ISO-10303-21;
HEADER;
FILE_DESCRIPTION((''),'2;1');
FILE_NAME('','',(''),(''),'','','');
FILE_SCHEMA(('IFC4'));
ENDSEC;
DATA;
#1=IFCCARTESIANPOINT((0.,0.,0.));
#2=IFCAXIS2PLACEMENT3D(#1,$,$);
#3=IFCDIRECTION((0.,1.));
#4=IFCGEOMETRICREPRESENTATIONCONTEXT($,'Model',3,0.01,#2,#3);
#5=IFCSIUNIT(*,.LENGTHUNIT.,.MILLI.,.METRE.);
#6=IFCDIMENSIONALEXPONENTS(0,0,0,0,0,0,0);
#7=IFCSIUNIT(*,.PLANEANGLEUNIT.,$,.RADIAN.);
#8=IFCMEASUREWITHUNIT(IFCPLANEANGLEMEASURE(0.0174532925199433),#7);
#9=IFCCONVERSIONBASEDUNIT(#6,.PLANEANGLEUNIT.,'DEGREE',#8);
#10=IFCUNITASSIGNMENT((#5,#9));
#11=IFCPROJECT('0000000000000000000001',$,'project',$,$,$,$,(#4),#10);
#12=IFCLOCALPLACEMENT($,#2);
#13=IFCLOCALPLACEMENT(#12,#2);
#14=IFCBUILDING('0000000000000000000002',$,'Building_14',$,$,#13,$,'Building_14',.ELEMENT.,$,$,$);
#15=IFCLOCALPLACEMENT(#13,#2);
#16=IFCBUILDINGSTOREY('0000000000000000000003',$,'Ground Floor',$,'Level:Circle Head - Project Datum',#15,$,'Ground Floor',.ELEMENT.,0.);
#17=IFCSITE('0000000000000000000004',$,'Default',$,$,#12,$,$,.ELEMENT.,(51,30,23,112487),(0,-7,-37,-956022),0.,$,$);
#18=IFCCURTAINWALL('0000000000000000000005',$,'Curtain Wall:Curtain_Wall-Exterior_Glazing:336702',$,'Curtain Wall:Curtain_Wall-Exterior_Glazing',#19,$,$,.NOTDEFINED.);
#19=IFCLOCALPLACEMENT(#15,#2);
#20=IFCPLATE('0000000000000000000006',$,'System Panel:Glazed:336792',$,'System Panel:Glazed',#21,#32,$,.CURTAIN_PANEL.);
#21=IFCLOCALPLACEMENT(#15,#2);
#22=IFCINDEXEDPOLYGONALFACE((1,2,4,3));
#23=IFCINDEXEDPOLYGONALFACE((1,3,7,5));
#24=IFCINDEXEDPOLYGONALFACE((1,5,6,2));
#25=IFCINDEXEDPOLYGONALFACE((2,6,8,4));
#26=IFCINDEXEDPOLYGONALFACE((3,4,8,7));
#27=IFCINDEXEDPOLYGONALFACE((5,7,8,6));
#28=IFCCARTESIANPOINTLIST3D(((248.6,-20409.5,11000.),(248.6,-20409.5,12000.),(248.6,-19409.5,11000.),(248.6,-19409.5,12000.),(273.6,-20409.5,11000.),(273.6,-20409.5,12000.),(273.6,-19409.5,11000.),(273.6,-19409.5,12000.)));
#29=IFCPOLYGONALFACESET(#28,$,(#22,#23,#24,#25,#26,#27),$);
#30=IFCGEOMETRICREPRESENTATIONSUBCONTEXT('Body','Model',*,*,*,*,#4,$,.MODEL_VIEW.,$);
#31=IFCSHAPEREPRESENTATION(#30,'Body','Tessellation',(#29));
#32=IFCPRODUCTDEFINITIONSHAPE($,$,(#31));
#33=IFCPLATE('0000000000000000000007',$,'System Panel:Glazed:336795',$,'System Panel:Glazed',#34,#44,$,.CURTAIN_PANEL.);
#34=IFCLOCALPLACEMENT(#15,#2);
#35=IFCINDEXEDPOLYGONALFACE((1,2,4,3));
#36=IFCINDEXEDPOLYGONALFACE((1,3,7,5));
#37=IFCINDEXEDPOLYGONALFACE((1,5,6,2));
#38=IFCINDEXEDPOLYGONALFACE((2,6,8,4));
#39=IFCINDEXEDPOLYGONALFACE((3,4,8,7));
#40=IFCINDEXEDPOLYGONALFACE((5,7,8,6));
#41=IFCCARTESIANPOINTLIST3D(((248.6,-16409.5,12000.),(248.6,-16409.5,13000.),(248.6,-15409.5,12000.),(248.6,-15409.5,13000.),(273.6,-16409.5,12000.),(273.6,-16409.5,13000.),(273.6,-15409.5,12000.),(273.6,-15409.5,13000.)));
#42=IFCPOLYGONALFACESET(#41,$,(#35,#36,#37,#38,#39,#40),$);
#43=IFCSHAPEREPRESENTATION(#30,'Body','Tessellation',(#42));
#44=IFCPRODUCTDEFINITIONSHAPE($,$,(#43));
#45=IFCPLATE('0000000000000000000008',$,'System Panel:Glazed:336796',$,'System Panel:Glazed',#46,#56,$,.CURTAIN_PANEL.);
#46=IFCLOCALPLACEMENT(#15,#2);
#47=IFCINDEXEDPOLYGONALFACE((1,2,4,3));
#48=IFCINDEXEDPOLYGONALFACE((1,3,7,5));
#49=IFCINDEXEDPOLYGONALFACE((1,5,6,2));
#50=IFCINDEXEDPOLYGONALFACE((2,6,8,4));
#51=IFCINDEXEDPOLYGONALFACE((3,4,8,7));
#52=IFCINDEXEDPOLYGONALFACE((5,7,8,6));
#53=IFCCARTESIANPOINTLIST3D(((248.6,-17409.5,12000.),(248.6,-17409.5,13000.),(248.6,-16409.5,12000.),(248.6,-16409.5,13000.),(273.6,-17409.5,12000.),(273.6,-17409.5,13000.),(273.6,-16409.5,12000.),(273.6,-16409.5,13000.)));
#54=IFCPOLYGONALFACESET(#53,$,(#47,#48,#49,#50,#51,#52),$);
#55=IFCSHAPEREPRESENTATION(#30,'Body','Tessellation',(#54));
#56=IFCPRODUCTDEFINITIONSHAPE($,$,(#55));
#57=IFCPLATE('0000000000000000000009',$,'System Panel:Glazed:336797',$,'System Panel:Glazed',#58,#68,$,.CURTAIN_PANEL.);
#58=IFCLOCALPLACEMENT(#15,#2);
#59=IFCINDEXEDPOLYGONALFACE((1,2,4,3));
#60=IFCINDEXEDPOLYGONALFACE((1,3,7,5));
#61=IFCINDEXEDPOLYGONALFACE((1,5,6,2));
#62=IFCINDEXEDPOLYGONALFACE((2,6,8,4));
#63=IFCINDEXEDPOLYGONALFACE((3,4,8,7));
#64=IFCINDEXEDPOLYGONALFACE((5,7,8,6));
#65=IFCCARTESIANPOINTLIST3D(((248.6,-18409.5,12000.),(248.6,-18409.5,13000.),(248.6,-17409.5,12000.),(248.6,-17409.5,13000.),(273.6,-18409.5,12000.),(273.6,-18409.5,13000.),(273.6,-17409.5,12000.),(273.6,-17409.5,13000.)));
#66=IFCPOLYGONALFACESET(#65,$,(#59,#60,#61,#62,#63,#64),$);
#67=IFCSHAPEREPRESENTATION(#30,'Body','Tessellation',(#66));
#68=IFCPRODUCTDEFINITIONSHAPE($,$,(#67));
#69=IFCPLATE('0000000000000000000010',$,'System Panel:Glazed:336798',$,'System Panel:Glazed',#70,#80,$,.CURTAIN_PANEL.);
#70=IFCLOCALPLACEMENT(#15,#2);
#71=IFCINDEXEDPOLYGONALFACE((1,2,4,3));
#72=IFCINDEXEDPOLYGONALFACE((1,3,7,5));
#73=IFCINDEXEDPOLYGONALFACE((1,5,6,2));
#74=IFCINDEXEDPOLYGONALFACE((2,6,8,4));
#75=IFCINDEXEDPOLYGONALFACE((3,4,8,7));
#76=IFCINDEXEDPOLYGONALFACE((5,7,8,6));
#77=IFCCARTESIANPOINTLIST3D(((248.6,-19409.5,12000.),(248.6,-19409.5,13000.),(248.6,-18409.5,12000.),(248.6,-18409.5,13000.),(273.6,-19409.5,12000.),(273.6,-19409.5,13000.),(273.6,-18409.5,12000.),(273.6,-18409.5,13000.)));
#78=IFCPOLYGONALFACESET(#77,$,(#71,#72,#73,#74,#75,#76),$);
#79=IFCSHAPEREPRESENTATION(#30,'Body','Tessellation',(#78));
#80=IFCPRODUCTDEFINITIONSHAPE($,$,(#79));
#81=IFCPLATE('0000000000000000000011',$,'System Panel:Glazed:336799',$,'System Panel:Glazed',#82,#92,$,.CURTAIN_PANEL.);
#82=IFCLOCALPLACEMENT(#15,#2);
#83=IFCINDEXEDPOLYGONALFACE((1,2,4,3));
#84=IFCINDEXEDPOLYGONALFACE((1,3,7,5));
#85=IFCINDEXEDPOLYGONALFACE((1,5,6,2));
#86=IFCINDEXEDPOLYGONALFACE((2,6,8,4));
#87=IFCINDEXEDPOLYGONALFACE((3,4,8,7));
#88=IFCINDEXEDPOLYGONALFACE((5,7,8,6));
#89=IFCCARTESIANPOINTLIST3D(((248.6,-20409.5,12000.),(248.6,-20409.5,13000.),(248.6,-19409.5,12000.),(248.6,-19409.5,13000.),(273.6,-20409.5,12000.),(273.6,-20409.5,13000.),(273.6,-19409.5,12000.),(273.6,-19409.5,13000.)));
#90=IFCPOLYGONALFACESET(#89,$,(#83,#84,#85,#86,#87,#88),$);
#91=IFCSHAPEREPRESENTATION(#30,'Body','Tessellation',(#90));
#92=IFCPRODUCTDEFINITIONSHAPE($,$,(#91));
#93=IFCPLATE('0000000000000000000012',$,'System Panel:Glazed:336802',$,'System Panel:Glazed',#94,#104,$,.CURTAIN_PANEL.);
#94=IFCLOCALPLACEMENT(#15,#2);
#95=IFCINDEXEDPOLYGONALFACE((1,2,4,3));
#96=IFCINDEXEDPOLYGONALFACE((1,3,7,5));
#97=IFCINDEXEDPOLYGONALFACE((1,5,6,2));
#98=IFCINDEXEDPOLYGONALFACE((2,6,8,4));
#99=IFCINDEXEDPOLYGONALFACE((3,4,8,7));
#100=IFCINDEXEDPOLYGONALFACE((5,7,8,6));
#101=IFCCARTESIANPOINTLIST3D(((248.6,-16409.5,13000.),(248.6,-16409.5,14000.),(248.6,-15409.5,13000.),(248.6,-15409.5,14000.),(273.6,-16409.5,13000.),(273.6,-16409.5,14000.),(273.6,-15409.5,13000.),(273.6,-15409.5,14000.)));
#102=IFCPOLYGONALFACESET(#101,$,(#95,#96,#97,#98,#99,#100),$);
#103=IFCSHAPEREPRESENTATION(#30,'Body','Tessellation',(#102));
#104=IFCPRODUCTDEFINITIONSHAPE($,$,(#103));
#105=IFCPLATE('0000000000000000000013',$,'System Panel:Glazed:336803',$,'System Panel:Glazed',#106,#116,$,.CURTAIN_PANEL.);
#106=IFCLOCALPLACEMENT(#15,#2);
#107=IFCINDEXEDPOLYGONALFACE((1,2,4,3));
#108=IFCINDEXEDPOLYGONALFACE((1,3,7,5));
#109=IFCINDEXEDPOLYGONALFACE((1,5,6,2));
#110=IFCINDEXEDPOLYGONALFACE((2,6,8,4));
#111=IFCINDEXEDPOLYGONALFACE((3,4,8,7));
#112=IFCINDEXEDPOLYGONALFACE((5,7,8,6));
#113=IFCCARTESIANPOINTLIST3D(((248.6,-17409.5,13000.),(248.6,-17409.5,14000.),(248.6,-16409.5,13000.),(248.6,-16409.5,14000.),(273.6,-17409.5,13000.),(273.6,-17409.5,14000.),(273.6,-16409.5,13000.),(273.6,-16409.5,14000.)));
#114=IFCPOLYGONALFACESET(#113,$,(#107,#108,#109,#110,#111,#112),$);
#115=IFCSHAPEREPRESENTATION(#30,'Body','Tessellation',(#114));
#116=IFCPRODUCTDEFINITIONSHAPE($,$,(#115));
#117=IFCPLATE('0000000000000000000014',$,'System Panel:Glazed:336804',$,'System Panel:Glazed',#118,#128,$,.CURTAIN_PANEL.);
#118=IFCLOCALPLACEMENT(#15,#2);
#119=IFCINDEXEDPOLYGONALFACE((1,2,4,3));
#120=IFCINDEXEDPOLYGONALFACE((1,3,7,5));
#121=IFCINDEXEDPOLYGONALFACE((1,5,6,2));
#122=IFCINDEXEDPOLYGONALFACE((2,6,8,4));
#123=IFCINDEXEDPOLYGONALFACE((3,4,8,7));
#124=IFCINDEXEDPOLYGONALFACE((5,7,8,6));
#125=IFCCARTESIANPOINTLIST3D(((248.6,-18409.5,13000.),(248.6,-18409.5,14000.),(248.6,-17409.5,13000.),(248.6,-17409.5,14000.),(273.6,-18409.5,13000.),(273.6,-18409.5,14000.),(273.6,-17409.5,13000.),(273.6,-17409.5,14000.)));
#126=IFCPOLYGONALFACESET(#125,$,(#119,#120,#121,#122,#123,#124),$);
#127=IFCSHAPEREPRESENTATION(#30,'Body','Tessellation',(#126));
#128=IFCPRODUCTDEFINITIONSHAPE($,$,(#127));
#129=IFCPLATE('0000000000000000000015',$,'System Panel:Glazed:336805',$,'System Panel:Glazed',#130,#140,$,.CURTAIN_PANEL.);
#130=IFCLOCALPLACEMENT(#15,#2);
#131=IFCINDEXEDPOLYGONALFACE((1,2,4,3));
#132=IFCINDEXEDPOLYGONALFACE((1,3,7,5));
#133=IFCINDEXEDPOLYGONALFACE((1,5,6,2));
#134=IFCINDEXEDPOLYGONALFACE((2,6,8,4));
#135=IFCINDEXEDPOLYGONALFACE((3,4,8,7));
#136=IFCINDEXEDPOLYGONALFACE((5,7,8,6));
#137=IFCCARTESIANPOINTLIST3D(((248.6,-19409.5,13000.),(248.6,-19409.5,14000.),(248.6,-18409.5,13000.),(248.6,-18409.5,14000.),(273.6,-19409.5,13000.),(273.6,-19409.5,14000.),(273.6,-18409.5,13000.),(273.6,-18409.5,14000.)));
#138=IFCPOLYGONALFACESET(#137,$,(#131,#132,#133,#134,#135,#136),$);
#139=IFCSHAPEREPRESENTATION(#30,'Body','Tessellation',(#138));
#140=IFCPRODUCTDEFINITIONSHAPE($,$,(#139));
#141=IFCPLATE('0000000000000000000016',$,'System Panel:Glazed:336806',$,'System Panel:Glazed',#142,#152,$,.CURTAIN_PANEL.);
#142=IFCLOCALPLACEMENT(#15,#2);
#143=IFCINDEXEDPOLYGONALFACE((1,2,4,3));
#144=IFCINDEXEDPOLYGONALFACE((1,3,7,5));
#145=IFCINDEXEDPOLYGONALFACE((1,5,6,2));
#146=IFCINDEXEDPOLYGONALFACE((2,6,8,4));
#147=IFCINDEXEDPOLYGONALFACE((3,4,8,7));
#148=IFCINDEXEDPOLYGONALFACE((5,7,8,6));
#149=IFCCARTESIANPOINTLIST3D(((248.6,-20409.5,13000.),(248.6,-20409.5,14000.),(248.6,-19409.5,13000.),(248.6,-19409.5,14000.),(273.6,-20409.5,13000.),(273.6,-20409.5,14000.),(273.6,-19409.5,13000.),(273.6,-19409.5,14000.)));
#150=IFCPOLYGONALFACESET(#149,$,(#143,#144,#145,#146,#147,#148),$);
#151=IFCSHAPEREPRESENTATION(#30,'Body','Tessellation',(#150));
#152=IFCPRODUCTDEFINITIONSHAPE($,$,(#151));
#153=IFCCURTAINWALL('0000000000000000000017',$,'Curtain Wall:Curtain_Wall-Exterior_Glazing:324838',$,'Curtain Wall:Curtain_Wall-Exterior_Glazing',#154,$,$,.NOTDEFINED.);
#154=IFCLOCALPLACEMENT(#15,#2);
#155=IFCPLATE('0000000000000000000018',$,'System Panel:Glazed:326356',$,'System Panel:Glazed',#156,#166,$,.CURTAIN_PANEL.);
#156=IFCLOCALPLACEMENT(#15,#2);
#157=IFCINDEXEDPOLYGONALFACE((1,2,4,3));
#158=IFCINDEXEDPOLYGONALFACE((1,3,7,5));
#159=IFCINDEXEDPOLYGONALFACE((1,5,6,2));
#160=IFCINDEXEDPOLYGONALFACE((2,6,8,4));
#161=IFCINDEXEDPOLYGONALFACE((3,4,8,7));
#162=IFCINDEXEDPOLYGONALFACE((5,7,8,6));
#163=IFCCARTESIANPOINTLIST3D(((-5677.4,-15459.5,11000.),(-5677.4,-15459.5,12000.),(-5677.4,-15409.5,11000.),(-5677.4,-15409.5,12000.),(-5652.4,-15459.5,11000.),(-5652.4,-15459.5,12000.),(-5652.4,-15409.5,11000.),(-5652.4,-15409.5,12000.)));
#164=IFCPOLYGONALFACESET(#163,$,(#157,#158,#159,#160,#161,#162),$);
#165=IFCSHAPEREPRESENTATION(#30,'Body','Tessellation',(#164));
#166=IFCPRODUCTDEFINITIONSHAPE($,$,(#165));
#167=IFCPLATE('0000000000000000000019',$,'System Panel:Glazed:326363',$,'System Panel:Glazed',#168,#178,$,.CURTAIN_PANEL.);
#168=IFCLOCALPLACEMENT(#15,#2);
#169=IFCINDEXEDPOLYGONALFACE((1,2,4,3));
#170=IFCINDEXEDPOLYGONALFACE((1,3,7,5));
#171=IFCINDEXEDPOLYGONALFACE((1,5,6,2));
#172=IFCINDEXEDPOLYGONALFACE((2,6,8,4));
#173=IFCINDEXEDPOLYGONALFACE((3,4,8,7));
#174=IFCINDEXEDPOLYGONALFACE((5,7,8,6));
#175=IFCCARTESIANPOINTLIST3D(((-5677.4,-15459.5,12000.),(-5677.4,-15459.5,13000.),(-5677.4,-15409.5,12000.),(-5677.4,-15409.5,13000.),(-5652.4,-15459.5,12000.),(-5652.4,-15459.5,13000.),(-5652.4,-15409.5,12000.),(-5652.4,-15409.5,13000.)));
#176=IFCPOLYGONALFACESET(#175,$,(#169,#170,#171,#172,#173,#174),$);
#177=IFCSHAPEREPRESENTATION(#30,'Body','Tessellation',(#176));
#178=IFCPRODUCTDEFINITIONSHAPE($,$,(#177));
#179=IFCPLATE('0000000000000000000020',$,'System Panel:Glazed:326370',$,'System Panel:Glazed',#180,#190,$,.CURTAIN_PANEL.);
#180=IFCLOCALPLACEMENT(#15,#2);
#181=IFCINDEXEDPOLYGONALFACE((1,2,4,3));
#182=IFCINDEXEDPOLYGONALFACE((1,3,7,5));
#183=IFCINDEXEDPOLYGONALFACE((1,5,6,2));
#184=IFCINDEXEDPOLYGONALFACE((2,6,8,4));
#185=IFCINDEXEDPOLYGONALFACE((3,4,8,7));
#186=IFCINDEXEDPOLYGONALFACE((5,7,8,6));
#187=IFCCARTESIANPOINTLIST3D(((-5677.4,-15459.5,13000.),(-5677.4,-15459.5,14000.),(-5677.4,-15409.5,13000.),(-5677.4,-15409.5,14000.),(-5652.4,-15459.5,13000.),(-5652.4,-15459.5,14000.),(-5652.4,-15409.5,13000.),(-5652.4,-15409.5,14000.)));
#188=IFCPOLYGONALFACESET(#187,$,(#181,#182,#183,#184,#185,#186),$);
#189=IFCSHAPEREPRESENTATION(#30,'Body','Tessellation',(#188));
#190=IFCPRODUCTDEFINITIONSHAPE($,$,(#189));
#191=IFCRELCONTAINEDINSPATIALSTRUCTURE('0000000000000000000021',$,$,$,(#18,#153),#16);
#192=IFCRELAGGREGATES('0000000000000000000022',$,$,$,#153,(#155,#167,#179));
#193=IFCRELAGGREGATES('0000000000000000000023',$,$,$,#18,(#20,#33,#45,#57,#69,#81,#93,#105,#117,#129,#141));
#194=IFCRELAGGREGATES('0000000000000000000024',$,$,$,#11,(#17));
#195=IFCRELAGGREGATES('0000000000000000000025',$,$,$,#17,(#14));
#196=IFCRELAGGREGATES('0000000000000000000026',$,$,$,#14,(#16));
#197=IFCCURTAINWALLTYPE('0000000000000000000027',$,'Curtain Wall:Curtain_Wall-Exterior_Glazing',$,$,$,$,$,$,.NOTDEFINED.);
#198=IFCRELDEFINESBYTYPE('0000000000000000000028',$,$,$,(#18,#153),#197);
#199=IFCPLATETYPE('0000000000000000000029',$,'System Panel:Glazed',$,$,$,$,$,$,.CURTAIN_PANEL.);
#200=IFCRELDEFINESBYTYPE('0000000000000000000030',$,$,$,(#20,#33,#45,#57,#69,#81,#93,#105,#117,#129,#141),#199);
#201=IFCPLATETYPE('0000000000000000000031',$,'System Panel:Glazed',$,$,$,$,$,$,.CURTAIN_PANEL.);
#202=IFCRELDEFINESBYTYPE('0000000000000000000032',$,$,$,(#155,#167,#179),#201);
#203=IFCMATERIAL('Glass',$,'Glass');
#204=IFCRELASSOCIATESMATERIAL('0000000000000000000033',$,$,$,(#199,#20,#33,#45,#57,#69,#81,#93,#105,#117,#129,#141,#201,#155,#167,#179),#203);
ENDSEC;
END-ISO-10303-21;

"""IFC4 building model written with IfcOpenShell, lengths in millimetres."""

from ifc_helpers import new_model, entity, si_unit, converted_unit, direction, frame, origin, place, context, subcontext, project, spatial, indexed_curve, outline, extrude, source, transform, mapped, material, type_object, type_shapes, element, aggregate, save


model = new_model("IFC4")

# Units and contexts
model_context = context("Model", 3, precision=0.01, world=origin(), true_north=direction((0.0, 1.0)))
body_context = subcontext(model_context, "Body", "Model", "MODEL_VIEW")
ifc_project = project(units=[si_unit("LENGTHUNIT", "METRE", prefix="MILLI"), converted_unit("PLANEANGLEUNIT", "DEGREE", entity("IfcPlaneAngleMeasure", 0.0174532925199433), si_unit("PLANEANGLEUNIT", "RADIAN"), dimensions=[0, 0, 0, 0, 0, 0, 0])], contexts=[model_context])

# Site, building, storey
site_placement = place(None, origin())
site = spatial("IfcSite", under=ifc_project, at=site_placement, Name="Default", CompositionType="ELEMENT", RefLatitude=(51, 30, 23, 112487), RefLongitude=(0, -7, -37, -956022), RefElevation=0.0)
building_placement = place(site_placement, origin())
building = spatial("IfcBuilding", under=site, at=building_placement, Name="Building_14", LongName="Building_14", CompositionType="ELEMENT")
storey_placement = place(building_placement, origin())
storey = spatial("IfcBuildingStorey", under=building, at=storey_placement, Name="Ground Floor", ObjectType="Level:Circle Head - Project Datum", LongName="Ground Floor", CompositionType="ELEMENT", Elevation=0.0)

# Curtain walls, plates
curtain_wall_type = type_object("IfcCurtainWallType", Name="Curtain Wall:Curtain_Wall-Exterior_Glazing", PredefinedType="NOTDEFINED")
curtain_wall_1_placement = place(storey_placement, origin())
curtain_wall_1 = element("IfcCurtainWall", 1, at=curtain_wall_1_placement, inside=storey, type_object=curtain_wall_type, Name="Curtain Wall:Curtain_Wall-Exterior_Glazing:336702", ObjectType="Curtain Wall:Curtain_Wall-Exterior_Glazing", PredefinedType="NOTDEFINED")
ifc_material = material(Name="Glass", Category="Glass")
plate_type_1 = type_object("IfcPlateType", Name="System Panel:Glazed", PredefinedType="CURTAIN_PANEL", material=ifc_material)
shared_shape_1 = source(origin(), body_context, "Body", "SweptSolid", [
    extrude(outline(indexed_curve([(-12.5, -500.0), (12.5, -500.0), (12.5, 500.0), (-12.5, 500.0), (-12.5, -500.0)], self_intersect=False)), frame((0.0, -37.0, 0.0), z_axis=(0.0, 0.0, 1.0), x_axis=(0.0, 1.0, 0.0)), (0.0, 0.0, 1.0), 1000.0),
])
type_shapes(plate_type_1, [shared_shape_1])
plate_1_placement = place(curtain_wall_1_placement, frame((298.1, -19909.5, 11000.0), z_axis=(0.0, 0.0, 1.0), x_axis=(0.0, -1.0, 0.0)))
plate_1 = element("IfcPlate", 2, at=plate_1_placement, type_object=plate_type_1, material=ifc_material, Name="System Panel:Glazed:336792", ObjectType="System Panel:Glazed", PredefinedType="CURTAIN_PANEL", context=body_context, shape_type="MappedRepresentation", body=[
    mapped(shared_shape_1, transform((0.0, 0.0, 0.0), scale=1.0)),
])
plate_2_placement = place(curtain_wall_1_placement, frame((298.1, -15909.5, 12000.0), z_axis=(0.0, 0.0, 1.0), x_axis=(0.0, -1.0, 0.0)))
plate_2 = element("IfcPlate", 3, at=plate_2_placement, type_object=plate_type_1, material=ifc_material, Name="System Panel:Glazed:336795", ObjectType="System Panel:Glazed", PredefinedType="CURTAIN_PANEL", context=body_context, shape_type="MappedRepresentation", body=[
    mapped(shared_shape_1, transform((0.0, 0.0, 0.0), scale=1.0)),
])
plate_3_placement = place(curtain_wall_1_placement, frame((298.1, -16909.5, 12000.0), z_axis=(0.0, 0.0, 1.0), x_axis=(0.0, -1.0, 0.0)))
plate_3 = element("IfcPlate", 4, at=plate_3_placement, type_object=plate_type_1, material=ifc_material, Name="System Panel:Glazed:336796", ObjectType="System Panel:Glazed", PredefinedType="CURTAIN_PANEL", context=body_context, shape_type="MappedRepresentation", body=[
    mapped(shared_shape_1, transform((0.0, 0.0, 0.0), scale=1.0)),
])
plate_4_placement = place(curtain_wall_1_placement, frame((298.1, -17909.5, 12000.0), z_axis=(0.0, 0.0, 1.0), x_axis=(0.0, -1.0, 0.0)))
plate_4 = element("IfcPlate", 5, at=plate_4_placement, type_object=plate_type_1, material=ifc_material, Name="System Panel:Glazed:336797", ObjectType="System Panel:Glazed", PredefinedType="CURTAIN_PANEL", context=body_context, shape_type="MappedRepresentation", body=[
    mapped(shared_shape_1, transform((0.0, 0.0, 0.0), scale=1.0)),
])
plate_5_placement = place(curtain_wall_1_placement, frame((298.1, -18909.5, 12000.0), z_axis=(0.0, 0.0, 1.0), x_axis=(0.0, -1.0, 0.0)))
plate_5 = element("IfcPlate", 6, at=plate_5_placement, type_object=plate_type_1, material=ifc_material, Name="System Panel:Glazed:336798", ObjectType="System Panel:Glazed", PredefinedType="CURTAIN_PANEL", context=body_context, shape_type="MappedRepresentation", body=[
    mapped(shared_shape_1, transform((0.0, 0.0, 0.0), scale=1.0)),
])
plate_6_placement = place(curtain_wall_1_placement, frame((298.1, -19909.5, 12000.0), z_axis=(0.0, 0.0, 1.0), x_axis=(0.0, -1.0, 0.0)))
plate_6 = element("IfcPlate", 7, at=plate_6_placement, type_object=plate_type_1, material=ifc_material, Name="System Panel:Glazed:336799", ObjectType="System Panel:Glazed", PredefinedType="CURTAIN_PANEL", context=body_context, shape_type="MappedRepresentation", body=[
    mapped(shared_shape_1, transform((0.0, 0.0, 0.0), scale=1.0)),
])
plate_7_placement = place(curtain_wall_1_placement, frame((298.1, -15909.5, 13000.0), z_axis=(0.0, 0.0, 1.0), x_axis=(0.0, -1.0, 0.0)))
plate_7 = element("IfcPlate", 8, at=plate_7_placement, type_object=plate_type_1, material=ifc_material, Name="System Panel:Glazed:336802", ObjectType="System Panel:Glazed", PredefinedType="CURTAIN_PANEL", context=body_context, shape_type="MappedRepresentation", body=[
    mapped(shared_shape_1, transform((0.0, 0.0, 0.0), scale=1.0)),
])
plate_8_placement = place(curtain_wall_1_placement, frame((298.1, -16909.5, 13000.0), z_axis=(0.0, 0.0, 1.0), x_axis=(0.0, -1.0, 0.0)))
plate_8 = element("IfcPlate", 9, at=plate_8_placement, type_object=plate_type_1, material=ifc_material, Name="System Panel:Glazed:336803", ObjectType="System Panel:Glazed", PredefinedType="CURTAIN_PANEL", context=body_context, shape_type="MappedRepresentation", body=[
    mapped(shared_shape_1, transform((0.0, 0.0, 0.0), scale=1.0)),
])
plate_9_placement = place(curtain_wall_1_placement, frame((298.1, -17909.5, 13000.0), z_axis=(0.0, 0.0, 1.0), x_axis=(0.0, -1.0, 0.0)))
plate_9 = element("IfcPlate", 10, at=plate_9_placement, type_object=plate_type_1, material=ifc_material, Name="System Panel:Glazed:336804", ObjectType="System Panel:Glazed", PredefinedType="CURTAIN_PANEL", context=body_context, shape_type="MappedRepresentation", body=[
    mapped(shared_shape_1, transform((0.0, 0.0, 0.0), scale=1.0)),
])
plate_10_placement = place(curtain_wall_1_placement, frame((298.1, -18909.5, 13000.0), z_axis=(0.0, 0.0, 1.0), x_axis=(0.0, -1.0, 0.0)))
plate_10 = element("IfcPlate", 11, at=plate_10_placement, type_object=plate_type_1, material=ifc_material, Name="System Panel:Glazed:336805", ObjectType="System Panel:Glazed", PredefinedType="CURTAIN_PANEL", context=body_context, shape_type="MappedRepresentation", body=[
    mapped(shared_shape_1, transform((0.0, 0.0, 0.0), scale=1.0)),
])
plate_11_placement = place(curtain_wall_1_placement, frame((298.1, -19909.5, 13000.0), z_axis=(0.0, 0.0, 1.0), x_axis=(0.0, -1.0, 0.0)))
plate_11 = element("IfcPlate", 12, at=plate_11_placement, type_object=plate_type_1, material=ifc_material, Name="System Panel:Glazed:336806", ObjectType="System Panel:Glazed", PredefinedType="CURTAIN_PANEL", context=body_context, shape_type="MappedRepresentation", body=[
    mapped(shared_shape_1, transform((0.0, 0.0, 0.0), scale=1.0)),
])
curtain_wall_2_placement = place(storey_placement, origin())
curtain_wall_2 = element("IfcCurtainWall", 13, at=curtain_wall_2_placement, inside=storey, type_object=curtain_wall_type, Name="Curtain Wall:Curtain_Wall-Exterior_Glazing:324838", ObjectType="Curtain Wall:Curtain_Wall-Exterior_Glazing", PredefinedType="NOTDEFINED")
plate_type_2 = type_object("IfcPlateType", Name="System Panel:Glazed", PredefinedType="CURTAIN_PANEL", material=ifc_material)
shared_shape_2 = source(origin(), body_context, "Body", "SweptSolid", [
    extrude(outline(indexed_curve([(-12.5, -25.0), (12.5, -25.0), (12.5, 25.0), (-12.5, 25.0), (-12.5, -25.0)], self_intersect=False)), frame((0.0, -37.0, 0.0), z_axis=(0.0, 0.0, 1.0), x_axis=(0.0, 1.0, 0.0)), (0.0, 0.0, 1.0), 1000.0),
])
type_shapes(plate_type_2, [shared_shape_2])
plate_12_placement = place(curtain_wall_2_placement, frame((-5701.9, -15434.5, 11000.0), z_axis=(0.0, 0.0, 1.0), x_axis=(0.0, 1.0, 0.0)))
plate_12 = element("IfcPlate", 14, at=plate_12_placement, type_object=plate_type_2, material=ifc_material, Name="System Panel:Glazed:326356", ObjectType="System Panel:Glazed", PredefinedType="CURTAIN_PANEL", context=body_context, shape_type="MappedRepresentation", body=[
    mapped(shared_shape_2, transform((0.0, 0.0, 0.0), scale=1.0)),
])
plate_13_placement = place(curtain_wall_2_placement, frame((-5701.9, -15434.5, 12000.0), z_axis=(0.0, 0.0, 1.0), x_axis=(0.0, 1.0, 0.0)))
plate_13 = element("IfcPlate", 15, at=plate_13_placement, type_object=plate_type_2, material=ifc_material, Name="System Panel:Glazed:326363", ObjectType="System Panel:Glazed", PredefinedType="CURTAIN_PANEL", context=body_context, shape_type="MappedRepresentation", body=[
    mapped(shared_shape_2, transform((0.0, 0.0, 0.0), scale=1.0)),
])
plate_14_placement = place(curtain_wall_2_placement, frame((-5701.9, -15434.5, 13000.0), z_axis=(0.0, 0.0, 1.0), x_axis=(0.0, 1.0, 0.0)))
plate_14 = element("IfcPlate", 16, at=plate_14_placement, type_object=plate_type_2, material=ifc_material, Name="System Panel:Glazed:326370", ObjectType="System Panel:Glazed", PredefinedType="CURTAIN_PANEL", context=body_context, shape_type="MappedRepresentation", body=[
    mapped(shared_shape_2, transform((0.0, 0.0, 0.0), scale=1.0)),
])
aggregate(curtain_wall_2, [plate_12, plate_13, plate_14])

aggregate(curtain_wall_1, [plate_1, plate_2, plate_3, plate_4, plate_5, plate_6, plate_7, plate_8, plate_9, plate_10, plate_11])

save(model, "model.ifc")
